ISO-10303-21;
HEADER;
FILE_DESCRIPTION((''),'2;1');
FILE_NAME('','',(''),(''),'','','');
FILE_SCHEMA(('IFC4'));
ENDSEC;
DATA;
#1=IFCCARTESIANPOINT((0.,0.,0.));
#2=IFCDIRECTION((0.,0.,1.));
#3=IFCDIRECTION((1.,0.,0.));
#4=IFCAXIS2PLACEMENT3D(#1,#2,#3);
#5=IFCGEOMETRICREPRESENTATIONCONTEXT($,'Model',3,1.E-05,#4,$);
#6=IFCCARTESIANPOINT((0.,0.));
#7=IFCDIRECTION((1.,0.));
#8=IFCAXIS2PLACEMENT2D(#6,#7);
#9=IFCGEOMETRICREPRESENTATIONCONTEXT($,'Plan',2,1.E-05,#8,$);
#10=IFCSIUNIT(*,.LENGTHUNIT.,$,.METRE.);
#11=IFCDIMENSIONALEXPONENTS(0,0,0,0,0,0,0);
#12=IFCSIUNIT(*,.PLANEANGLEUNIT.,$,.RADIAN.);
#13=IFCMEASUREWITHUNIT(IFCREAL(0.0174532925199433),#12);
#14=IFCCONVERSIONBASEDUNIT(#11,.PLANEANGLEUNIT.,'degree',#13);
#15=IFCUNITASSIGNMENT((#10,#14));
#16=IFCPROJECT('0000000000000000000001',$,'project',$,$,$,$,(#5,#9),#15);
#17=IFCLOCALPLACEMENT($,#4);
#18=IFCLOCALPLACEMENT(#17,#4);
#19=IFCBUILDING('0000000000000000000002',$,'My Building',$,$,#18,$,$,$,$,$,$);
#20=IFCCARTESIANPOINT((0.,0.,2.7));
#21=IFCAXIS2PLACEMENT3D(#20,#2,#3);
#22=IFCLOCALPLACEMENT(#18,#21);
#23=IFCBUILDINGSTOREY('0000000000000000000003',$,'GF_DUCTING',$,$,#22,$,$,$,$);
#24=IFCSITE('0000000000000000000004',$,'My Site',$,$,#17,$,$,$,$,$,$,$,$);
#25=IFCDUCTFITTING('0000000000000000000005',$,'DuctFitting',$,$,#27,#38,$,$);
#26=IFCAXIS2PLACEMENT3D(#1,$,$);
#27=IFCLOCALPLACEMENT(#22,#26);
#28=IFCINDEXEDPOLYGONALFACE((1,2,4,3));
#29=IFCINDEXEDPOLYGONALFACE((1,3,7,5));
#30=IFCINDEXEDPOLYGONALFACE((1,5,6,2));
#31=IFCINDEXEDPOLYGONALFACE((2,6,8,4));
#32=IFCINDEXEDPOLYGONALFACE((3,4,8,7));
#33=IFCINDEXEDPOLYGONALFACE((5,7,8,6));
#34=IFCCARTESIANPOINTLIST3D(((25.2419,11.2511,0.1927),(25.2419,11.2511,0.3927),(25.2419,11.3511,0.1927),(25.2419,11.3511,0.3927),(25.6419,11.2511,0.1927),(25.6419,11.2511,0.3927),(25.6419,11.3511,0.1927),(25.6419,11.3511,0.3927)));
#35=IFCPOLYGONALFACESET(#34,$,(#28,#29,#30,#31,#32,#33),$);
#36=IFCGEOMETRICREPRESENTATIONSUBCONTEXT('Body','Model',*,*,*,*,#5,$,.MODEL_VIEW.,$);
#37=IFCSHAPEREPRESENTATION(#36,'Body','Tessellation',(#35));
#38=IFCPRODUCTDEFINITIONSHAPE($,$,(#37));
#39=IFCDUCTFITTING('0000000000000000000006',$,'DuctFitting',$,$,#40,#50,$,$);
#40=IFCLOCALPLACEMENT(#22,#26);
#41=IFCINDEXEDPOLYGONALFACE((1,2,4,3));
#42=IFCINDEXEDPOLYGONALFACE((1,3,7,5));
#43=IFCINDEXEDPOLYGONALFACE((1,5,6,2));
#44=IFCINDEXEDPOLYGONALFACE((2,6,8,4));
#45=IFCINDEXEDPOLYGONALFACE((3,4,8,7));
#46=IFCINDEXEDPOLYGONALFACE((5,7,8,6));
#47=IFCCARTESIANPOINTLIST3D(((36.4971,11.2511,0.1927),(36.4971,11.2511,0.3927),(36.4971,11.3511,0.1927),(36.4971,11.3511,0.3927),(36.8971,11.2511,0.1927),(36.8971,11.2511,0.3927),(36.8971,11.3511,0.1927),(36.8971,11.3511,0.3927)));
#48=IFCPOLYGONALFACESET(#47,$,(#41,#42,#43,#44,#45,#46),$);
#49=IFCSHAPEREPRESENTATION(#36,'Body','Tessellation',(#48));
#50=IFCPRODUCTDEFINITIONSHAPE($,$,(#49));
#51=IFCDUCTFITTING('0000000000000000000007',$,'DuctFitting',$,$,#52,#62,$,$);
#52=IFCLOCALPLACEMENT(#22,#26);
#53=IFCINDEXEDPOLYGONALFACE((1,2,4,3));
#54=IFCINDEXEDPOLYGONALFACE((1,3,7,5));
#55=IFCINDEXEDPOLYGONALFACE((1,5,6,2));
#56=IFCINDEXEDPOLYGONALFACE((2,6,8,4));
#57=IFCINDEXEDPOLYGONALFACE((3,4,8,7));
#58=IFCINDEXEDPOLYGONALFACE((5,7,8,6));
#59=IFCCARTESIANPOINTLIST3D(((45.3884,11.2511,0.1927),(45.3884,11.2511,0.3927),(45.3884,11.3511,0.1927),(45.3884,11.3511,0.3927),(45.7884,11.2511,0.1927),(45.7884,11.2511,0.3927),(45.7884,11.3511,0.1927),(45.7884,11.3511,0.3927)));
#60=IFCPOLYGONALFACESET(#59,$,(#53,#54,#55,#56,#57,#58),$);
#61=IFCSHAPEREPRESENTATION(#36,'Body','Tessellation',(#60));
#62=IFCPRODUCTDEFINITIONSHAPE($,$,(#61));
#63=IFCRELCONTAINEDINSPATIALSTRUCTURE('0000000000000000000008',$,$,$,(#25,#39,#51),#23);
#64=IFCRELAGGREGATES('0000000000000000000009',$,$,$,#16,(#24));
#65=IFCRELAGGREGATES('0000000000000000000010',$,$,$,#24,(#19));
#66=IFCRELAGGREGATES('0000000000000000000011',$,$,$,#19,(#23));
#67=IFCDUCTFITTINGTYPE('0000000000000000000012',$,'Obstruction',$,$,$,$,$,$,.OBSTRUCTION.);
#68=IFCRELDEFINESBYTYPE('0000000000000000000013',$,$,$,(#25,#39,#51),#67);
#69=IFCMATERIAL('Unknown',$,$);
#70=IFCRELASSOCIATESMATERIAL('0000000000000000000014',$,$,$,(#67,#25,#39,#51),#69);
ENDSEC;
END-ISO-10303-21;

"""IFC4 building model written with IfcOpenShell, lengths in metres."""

from ifc_helpers import new_model, entity, si_unit, converted_unit, frame, origin_with_axes, origin_2d_with_axis, place, context, subcontext, project, spatial, rectangle, extrude, material, material_profile, profile_set, profile_usage, type_object, element, save


model = new_model("IFC4")

# Units and contexts
model_context = context("Model", 3, precision=1e-05, world=origin_with_axes())
plan_context = context("Plan", 2, precision=1e-05, world=origin_2d_with_axis())
body_context = subcontext(model_context, "Body", "Model", "MODEL_VIEW")
ifc_project = project(units=[si_unit("LENGTHUNIT", "METRE"), converted_unit("PLANEANGLEUNIT", "degree", entity("IfcReal", 0.0174532925199433), si_unit("PLANEANGLEUNIT", "RADIAN"), dimensions=[0, 0, 0, 0, 0, 0, 0])], contexts=[model_context, plan_context])

# Site, building, storey
site_placement = place(None, origin_with_axes())
site = spatial("IfcSite", under=ifc_project, at=site_placement, Name="My Site")
building_placement = place(site_placement, origin_with_axes())
building = spatial("IfcBuilding", under=site, at=building_placement, Name="My Building")
storey_placement = place(building_placement, frame((0.0, 0.0, 2.7), z_axis=(0.0, 0.0, 1.0), x_axis=(1.0, 0.0, 0.0)))
storey = spatial("IfcBuildingStorey", under=building, at=storey_placement, Name="GF_DUCTING")

# Shared definitions
ifc_material = material(Name="Unknown")

# Duct fittings
ifc_material_profile_1 = material_profile(ifc_material, rectangle(XDim=0.4, YDim=0.2))
ifc_profile_set_1 = profile_set([ifc_material_profile_1])
duct_fitting_type = type_object("IfcDuctFittingType", Name="Obstruction", PredefinedType="OBSTRUCTION", material=ifc_profile_set_1)
ifc_profile_usage_1 = profile_usage(ifc_profile_set_1, cardinal=5)
duct_fitting_1_placement = place(storey_placement, frame((25.4419, 11.2511, 0.2927), z_axis=(0.0, 1.0, 0.0), x_axis=(-1.0, 0.0, 0.0)))
element("IfcDuctFitting", 1, at=duct_fitting_1_placement, inside=storey, type_object=duct_fitting_type, material=ifc_profile_usage_1, Name="DuctFitting", context=body_context, shape_type="SweptSolid", body=[
    extrude(rectangle(XDim=0.4, YDim=0.2), origin_with_axes(), (0.0, 0.0, 1.0), 0.1),
])
ifc_profile_usage_2 = profile_usage(ifc_profile_set_1, cardinal=5)
duct_fitting_2_placement = place(storey_placement, frame((36.6971, 11.2511, 0.2927), z_axis=(0.0, 1.0, 0.0), x_axis=(-1.0, 0.0, 0.0)))
element("IfcDuctFitting", 2, at=duct_fitting_2_placement, inside=storey, type_object=duct_fitting_type, material=ifc_profile_usage_2, Name="DuctFitting", context=body_context, shape_type="SweptSolid", body=[
    extrude(rectangle(XDim=0.4, YDim=0.2), origin_with_axes(), (0.0, 0.0, 1.0), 0.1),
])
ifc_profile_usage_3 = profile_usage(ifc_profile_set_1, cardinal=5)
duct_fitting_3_placement = place(storey_placement, frame((45.5884, 11.2511, 0.2927), z_axis=(0.0, 1.0, 0.0), x_axis=(-1.0, 0.0, 0.0)))
element("IfcDuctFitting", 3, at=duct_fitting_3_placement, inside=storey, type_object=duct_fitting_type, material=ifc_profile_usage_3, Name="DuctFitting", context=body_context, shape_type="SweptSolid", body=[
    extrude(rectangle(XDim=0.4, YDim=0.2), origin_with_axes(), (0.0, 0.0, 1.0), 0.1),
])

save(model, "model.ifc")
